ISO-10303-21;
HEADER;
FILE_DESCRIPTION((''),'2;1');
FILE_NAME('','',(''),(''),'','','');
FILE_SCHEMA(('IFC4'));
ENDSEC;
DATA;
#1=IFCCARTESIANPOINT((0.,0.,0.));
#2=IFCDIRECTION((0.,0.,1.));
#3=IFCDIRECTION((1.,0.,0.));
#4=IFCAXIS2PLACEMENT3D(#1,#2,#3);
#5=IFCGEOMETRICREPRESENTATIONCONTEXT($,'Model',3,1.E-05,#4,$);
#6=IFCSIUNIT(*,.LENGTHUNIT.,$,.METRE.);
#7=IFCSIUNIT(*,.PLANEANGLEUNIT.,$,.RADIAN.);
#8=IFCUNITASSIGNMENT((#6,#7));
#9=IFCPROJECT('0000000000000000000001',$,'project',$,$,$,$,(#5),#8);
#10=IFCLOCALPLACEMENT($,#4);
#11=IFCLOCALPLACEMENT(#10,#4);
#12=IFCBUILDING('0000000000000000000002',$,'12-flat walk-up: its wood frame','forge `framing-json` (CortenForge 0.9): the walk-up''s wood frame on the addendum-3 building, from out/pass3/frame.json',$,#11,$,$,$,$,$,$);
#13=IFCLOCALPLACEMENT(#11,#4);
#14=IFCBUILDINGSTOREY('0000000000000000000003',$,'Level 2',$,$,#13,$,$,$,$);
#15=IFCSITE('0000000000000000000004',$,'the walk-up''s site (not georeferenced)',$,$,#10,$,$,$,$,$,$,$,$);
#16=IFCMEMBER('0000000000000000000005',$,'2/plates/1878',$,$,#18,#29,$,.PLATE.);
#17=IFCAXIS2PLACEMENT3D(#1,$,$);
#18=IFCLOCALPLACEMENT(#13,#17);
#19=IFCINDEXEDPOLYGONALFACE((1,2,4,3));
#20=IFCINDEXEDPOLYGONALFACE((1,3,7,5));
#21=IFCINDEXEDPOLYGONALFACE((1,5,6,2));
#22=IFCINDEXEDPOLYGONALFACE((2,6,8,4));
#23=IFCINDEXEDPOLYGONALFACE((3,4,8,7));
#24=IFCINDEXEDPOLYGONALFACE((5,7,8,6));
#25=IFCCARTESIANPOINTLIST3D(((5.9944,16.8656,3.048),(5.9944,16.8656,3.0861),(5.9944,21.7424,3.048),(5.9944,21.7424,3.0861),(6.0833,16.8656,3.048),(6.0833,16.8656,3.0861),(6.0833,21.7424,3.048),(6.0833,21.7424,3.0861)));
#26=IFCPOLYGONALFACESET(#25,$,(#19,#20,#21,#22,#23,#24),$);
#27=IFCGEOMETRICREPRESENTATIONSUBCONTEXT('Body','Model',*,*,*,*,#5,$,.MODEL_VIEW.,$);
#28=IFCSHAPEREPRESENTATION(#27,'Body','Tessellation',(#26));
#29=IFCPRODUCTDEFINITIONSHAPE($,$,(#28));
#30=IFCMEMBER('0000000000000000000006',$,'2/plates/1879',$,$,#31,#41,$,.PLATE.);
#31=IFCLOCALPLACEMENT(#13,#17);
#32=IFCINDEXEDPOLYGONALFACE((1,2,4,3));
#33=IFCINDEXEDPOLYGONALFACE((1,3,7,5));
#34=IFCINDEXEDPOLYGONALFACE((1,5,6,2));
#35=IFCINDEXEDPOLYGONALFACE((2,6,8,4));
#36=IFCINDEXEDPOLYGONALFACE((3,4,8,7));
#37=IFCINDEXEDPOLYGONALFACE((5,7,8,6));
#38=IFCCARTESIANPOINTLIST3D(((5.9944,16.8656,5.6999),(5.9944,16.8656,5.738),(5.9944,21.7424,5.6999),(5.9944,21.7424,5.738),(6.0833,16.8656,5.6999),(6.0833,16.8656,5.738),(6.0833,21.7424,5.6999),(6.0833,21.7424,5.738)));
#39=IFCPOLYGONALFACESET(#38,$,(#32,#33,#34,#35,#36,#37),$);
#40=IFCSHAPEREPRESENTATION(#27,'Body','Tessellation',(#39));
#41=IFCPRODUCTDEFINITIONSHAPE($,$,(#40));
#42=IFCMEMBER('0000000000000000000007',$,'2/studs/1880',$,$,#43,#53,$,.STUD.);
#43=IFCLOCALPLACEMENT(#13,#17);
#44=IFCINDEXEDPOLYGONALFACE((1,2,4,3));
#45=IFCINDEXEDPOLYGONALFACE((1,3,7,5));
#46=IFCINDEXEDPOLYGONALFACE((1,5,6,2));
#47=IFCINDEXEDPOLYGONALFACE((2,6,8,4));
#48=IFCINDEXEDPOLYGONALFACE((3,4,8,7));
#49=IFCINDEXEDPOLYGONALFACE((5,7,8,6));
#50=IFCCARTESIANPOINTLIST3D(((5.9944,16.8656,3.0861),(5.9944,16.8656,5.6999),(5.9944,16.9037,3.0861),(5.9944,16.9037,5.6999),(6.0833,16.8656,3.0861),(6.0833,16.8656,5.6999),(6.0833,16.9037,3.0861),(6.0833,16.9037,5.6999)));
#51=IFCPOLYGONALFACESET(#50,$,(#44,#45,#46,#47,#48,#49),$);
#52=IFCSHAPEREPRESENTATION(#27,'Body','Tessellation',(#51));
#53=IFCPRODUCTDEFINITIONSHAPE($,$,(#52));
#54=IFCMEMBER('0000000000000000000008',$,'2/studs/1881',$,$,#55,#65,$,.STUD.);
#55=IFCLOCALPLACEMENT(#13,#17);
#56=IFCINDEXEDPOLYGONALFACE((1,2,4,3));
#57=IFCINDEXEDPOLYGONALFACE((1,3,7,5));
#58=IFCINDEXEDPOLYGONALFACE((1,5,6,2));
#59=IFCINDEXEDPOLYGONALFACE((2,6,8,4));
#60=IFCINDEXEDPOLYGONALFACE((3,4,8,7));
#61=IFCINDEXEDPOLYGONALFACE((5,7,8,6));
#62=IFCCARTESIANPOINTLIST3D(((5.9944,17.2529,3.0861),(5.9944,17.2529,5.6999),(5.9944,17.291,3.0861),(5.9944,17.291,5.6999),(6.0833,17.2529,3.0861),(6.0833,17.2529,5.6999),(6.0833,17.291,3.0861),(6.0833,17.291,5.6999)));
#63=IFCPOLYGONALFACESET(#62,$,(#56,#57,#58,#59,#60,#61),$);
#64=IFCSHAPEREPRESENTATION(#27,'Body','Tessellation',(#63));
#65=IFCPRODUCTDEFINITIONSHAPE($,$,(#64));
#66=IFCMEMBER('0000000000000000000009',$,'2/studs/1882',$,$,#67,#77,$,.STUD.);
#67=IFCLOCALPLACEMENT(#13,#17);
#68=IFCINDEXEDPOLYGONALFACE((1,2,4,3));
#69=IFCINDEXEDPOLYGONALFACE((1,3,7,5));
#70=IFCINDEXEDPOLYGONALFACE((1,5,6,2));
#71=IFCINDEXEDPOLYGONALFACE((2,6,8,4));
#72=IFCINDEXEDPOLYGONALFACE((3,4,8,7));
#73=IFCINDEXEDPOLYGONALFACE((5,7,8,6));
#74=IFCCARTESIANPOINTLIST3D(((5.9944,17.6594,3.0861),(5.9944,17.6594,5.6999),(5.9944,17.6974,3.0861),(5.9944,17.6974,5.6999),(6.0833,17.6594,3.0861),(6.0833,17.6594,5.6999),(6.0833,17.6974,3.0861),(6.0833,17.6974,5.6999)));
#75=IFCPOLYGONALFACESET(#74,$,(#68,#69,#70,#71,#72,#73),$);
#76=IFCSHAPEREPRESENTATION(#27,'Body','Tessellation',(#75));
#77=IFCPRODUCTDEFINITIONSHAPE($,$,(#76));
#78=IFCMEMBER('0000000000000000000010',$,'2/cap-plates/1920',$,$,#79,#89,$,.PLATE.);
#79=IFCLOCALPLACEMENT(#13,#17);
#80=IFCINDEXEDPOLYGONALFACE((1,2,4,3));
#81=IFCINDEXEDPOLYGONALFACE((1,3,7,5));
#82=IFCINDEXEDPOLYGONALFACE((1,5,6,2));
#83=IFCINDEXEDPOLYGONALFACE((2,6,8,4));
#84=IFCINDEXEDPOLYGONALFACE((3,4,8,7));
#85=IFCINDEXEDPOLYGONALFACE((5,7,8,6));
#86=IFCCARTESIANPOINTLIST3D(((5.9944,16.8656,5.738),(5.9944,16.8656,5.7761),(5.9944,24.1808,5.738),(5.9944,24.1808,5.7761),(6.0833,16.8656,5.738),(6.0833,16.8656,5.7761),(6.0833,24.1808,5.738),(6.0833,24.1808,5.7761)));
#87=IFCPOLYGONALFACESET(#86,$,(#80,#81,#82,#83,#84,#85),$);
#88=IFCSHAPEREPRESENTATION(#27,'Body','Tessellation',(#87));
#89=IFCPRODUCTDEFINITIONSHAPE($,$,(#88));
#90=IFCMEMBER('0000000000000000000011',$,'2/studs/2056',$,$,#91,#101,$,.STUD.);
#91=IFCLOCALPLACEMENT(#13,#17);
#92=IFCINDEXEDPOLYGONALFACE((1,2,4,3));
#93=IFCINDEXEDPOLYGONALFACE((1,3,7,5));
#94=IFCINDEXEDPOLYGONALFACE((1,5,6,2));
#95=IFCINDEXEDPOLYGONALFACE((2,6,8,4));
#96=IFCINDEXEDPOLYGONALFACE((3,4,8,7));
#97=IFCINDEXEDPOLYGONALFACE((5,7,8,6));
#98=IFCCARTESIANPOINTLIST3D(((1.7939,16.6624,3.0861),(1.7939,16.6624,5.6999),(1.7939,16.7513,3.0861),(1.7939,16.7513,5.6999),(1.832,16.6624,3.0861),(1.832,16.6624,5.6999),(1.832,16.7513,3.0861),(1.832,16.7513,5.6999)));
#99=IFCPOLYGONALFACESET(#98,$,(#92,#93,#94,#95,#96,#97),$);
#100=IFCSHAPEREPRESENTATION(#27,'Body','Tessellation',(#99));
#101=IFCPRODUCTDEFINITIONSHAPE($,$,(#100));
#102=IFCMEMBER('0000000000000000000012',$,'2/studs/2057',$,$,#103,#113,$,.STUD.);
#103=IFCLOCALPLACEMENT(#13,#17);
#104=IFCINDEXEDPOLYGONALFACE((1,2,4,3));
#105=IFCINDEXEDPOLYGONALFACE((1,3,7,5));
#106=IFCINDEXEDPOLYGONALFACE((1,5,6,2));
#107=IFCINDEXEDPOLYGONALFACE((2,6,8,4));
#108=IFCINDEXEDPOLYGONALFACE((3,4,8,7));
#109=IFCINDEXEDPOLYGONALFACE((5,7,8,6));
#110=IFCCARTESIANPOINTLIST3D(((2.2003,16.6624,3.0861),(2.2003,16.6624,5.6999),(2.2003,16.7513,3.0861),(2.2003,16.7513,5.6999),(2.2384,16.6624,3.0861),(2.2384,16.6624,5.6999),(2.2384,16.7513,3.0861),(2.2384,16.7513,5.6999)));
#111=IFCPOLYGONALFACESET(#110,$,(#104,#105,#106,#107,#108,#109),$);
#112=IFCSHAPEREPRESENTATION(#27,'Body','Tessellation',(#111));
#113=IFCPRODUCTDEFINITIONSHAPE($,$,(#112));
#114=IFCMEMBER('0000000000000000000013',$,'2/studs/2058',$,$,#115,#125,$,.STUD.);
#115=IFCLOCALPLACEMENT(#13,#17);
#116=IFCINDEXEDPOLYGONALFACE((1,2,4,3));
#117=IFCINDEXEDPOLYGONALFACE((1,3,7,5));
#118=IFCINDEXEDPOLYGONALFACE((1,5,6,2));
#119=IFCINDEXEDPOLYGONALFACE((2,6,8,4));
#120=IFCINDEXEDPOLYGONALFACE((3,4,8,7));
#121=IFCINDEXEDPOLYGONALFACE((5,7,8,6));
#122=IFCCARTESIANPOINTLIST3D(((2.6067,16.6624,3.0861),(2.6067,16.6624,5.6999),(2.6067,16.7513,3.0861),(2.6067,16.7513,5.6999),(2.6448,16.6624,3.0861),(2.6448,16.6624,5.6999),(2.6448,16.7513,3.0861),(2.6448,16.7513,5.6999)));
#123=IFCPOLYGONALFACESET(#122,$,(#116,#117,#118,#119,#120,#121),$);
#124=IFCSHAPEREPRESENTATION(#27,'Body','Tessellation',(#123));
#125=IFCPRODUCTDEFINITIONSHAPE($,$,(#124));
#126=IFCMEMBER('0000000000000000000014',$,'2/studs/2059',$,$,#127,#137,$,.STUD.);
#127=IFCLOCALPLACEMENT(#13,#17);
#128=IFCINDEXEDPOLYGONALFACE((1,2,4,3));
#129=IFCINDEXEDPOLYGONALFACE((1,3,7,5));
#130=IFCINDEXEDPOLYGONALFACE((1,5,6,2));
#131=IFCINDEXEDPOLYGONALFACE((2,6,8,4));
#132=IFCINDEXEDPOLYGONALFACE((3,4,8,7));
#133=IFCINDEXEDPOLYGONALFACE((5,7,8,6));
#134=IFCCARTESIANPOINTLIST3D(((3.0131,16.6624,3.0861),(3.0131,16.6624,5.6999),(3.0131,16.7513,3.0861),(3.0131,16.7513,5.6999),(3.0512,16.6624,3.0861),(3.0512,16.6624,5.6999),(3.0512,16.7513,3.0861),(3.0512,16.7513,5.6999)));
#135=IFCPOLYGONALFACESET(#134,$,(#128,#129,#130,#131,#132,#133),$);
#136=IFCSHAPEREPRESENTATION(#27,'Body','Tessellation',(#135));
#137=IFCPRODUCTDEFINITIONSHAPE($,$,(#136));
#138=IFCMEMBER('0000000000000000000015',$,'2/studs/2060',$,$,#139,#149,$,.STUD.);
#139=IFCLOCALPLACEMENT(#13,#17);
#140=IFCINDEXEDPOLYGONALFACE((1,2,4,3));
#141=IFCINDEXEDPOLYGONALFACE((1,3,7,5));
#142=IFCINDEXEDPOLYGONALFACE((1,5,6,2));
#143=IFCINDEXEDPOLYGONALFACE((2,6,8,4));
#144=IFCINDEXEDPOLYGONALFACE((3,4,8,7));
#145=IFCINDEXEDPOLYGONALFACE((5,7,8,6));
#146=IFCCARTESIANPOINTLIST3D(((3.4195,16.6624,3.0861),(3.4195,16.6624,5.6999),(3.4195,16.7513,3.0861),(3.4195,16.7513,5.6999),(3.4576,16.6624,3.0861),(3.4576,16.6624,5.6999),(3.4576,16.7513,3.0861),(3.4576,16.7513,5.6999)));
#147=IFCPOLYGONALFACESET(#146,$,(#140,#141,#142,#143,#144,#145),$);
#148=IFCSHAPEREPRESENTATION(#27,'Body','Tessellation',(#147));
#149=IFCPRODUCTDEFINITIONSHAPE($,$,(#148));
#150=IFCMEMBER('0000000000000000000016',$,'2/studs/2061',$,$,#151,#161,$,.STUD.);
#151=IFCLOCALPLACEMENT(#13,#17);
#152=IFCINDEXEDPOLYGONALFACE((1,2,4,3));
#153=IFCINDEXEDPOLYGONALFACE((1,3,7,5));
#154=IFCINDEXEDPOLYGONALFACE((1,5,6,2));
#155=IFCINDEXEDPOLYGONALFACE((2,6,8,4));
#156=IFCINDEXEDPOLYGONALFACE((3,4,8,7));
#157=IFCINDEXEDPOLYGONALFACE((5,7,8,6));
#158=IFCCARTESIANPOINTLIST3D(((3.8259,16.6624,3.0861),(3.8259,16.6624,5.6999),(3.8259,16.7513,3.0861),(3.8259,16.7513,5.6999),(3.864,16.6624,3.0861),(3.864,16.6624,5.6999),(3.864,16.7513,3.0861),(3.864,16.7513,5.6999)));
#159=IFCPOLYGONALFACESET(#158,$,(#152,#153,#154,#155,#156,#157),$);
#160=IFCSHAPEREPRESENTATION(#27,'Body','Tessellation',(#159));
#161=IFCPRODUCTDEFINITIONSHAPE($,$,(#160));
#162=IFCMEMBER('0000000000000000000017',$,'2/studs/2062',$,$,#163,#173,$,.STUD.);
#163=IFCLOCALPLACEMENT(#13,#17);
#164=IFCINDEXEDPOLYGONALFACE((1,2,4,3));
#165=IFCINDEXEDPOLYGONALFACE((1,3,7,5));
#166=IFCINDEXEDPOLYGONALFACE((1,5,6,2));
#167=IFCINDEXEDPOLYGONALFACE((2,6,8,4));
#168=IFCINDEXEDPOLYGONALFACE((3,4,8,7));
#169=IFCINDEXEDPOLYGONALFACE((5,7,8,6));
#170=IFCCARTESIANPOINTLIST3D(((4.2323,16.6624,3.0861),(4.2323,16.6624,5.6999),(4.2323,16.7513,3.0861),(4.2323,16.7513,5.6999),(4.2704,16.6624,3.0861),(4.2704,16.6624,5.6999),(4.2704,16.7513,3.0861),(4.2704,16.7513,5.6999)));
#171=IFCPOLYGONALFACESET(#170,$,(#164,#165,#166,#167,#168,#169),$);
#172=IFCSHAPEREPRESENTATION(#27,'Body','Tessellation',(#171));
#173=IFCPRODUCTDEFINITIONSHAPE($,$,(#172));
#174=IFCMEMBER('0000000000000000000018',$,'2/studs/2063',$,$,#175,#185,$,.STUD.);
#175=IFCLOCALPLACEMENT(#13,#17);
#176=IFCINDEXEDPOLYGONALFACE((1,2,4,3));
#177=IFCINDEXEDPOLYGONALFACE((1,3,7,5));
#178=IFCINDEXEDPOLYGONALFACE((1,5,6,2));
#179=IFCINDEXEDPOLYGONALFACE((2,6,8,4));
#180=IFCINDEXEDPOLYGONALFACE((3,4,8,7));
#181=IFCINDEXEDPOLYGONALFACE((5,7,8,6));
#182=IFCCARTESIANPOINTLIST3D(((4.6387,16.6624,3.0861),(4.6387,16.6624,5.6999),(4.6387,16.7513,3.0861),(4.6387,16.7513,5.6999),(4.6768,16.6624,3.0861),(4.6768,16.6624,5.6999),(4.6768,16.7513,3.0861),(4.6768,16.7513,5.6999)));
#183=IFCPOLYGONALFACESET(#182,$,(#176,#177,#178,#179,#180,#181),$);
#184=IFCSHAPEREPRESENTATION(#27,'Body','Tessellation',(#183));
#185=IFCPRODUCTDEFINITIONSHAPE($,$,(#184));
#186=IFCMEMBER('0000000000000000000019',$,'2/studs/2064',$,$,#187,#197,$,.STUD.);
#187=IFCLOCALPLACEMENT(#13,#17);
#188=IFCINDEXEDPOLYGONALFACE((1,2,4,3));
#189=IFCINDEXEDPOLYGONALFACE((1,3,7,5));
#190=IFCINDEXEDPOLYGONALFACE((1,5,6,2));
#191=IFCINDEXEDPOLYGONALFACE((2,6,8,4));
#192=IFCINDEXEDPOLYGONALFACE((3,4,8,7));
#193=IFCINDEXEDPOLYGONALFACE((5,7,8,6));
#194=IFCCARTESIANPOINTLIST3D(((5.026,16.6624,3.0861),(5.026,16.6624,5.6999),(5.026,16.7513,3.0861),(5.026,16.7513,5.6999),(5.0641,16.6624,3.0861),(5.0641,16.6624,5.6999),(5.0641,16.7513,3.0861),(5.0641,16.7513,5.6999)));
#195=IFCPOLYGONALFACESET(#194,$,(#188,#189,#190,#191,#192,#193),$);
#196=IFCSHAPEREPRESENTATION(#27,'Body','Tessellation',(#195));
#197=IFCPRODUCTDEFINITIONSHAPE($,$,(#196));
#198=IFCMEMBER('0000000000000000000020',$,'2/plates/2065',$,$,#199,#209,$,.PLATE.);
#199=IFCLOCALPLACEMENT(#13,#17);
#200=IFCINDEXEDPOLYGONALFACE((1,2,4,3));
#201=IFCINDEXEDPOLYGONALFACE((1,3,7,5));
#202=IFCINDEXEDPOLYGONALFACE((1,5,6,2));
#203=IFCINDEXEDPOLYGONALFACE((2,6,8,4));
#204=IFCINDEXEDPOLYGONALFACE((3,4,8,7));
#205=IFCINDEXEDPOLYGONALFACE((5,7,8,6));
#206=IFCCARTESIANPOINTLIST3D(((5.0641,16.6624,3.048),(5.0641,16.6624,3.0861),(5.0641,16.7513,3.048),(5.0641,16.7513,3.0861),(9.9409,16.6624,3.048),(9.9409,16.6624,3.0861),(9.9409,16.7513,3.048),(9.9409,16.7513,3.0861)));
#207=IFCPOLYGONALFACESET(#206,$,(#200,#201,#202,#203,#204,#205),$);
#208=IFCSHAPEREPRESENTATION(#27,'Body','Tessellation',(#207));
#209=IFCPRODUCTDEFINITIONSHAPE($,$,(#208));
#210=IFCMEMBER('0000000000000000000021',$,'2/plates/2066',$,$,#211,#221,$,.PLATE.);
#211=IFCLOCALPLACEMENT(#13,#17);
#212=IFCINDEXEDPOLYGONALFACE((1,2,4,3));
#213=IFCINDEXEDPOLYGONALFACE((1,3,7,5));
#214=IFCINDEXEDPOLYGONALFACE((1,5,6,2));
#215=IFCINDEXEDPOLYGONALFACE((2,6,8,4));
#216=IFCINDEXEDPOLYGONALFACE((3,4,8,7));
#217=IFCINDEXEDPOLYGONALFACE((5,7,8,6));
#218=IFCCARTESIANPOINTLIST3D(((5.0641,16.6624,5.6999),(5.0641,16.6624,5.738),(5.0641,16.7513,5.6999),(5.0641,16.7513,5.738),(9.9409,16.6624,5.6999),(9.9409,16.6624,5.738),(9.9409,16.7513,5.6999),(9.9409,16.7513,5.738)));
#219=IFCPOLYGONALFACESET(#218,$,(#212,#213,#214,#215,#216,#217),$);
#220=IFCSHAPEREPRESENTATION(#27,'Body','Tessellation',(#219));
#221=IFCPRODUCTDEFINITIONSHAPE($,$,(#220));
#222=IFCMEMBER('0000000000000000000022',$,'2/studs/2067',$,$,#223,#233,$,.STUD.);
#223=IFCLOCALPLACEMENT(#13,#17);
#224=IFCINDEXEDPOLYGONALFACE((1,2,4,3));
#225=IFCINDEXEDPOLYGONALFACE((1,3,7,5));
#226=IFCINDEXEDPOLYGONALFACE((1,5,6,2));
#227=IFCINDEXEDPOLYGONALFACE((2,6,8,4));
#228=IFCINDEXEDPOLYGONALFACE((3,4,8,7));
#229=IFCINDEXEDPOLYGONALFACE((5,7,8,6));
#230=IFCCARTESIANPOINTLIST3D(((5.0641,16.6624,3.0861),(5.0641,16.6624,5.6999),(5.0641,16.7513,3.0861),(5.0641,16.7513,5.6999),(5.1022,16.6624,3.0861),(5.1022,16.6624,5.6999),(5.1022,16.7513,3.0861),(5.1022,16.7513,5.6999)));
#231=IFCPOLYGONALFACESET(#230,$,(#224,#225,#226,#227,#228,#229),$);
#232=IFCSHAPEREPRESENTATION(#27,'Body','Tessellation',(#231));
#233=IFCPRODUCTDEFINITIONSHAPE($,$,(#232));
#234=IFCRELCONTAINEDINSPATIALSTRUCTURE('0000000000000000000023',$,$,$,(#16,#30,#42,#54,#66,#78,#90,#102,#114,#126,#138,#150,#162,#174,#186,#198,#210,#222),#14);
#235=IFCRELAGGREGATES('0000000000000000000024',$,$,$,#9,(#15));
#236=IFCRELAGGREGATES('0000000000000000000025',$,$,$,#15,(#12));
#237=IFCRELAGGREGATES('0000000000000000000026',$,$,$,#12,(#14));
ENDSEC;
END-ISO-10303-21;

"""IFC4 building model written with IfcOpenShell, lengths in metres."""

from ifc_helpers import new_model, si_unit, frame, frame_2d, origin, origin_with_axes, place, context, subcontext, project, spatial, rectangle, extrude, element, save


model = new_model("IFC4")

# Units and contexts
model_context = context("Model", 3, precision=1e-05, world=origin_with_axes())
body_context = subcontext(model_context, "Body", "Model", "MODEL_VIEW")
ifc_project = project(units=[si_unit("LENGTHUNIT", "METRE"), si_unit("PLANEANGLEUNIT", "RADIAN")], contexts=[model_context])

# Site, building, storey
site_placement = place(None, origin_with_axes())
site = spatial("IfcSite", under=ifc_project, at=site_placement, Name="the walk-up's site (not georeferenced)")
building_placement = place(site_placement, origin_with_axes())
building = spatial("IfcBuilding", under=site, at=building_placement, Name="12-flat walk-up: its wood frame", Description="forge `framing-json` (CortenForge 0.9): the walk-up's wood frame on the addendum-3 building, from out/pass3/frame.json")
storey_placement = place(building_placement, origin_with_axes())
storey = spatial("IfcBuildingStorey", under=building, at=storey_placement, Name="Level 2")

# Members
for number, where, z_axis, x_axis, name in (
    (1, (5.9944, 16.8656, 3.048), (0.0, 0.0, 1.0), (1.0, 0.0, 0.0), "2/plates/1878"),
    (2, (5.9944, 16.8656, 5.6999), (0.0, 0.0, 1.0), (1.0, 0.0, 0.0), "2/plates/1879"),
):
    element("IfcMember", number, at=place(storey_placement, frame(where, z_axis=z_axis, x_axis=x_axis)), inside=storey, Name=name, PredefinedType="PLATE", context=body_context, shape_type="SweptSolid", body=[
        extrude(rectangle(XDim=0.0889, YDim=4.8768, at=frame_2d((0.0445, 2.4384))), origin(), (0.0, 0.0, 1.0), 0.0381),
    ])
for number, where, z_axis, x_axis, name in (
    (3, (5.9944, 16.8656, 3.0861), (0.0, 0.0, 1.0), (1.0, 0.0, 0.0), "2/studs/1880"),
    (4, (5.9944, 17.2529, 3.0861), (0.0, 0.0, 1.0), (1.0, 0.0, 0.0), "2/studs/1881"),
    (5, (5.9944, 17.6593, 3.0861), (0.0, 0.0, 1.0), (1.0, 0.0, 0.0), "2/studs/1882"),
):
    element("IfcMember", number, at=place(storey_placement, frame(where, z_axis=z_axis, x_axis=x_axis)), inside=storey, Name=name, PredefinedType="STUD", context=body_context, shape_type="SweptSolid", body=[
        extrude(rectangle(XDim=0.0889, YDim=0.0381, at=frame_2d((0.0445, 0.0191))), origin(), (0.0, 0.0, 1.0), 2.6138),
    ])
member_1_placement = place(storey_placement, frame((5.9944, 16.8656, 5.738), z_axis=(0.0, 0.0, 1.0), x_axis=(1.0, 0.0, 0.0)))
element("IfcMember", 6, at=member_1_placement, inside=storey, Name="2/cap-plates/1920", PredefinedType="PLATE", context=body_context, shape_type="SweptSolid", body=[
    extrude(rectangle(XDim=0.0889, YDim=7.3152, at=frame_2d((0.0445, 3.6576))), origin(), (0.0, 0.0, 1.0), 0.0381),
])
member_2_placement = place(storey_placement, frame((1.7939, 16.6624, 3.0861), z_axis=(0.0, 0.0, 1.0), x_axis=(1.0, 0.0, 0.0)))
element("IfcMember", 7, at=member_2_placement, inside=storey, Name="2/studs/2056", PredefinedType="STUD", context=body_context, shape_type="SweptSolid", body=[
    extrude(rectangle(XDim=0.0381, YDim=0.0889, at=frame_2d((0.019, 0.0444))), origin(), (0.0, 0.0, 1.0), 2.6138),
])
for number, where, z_axis, x_axis, name in (
    (8, (2.2003, 16.6624, 3.0861), (0.0, 0.0, 1.0), (1.0, 0.0, 0.0), "2/studs/2057"),
    (9, (2.6067, 16.6624, 3.0861), (0.0, 0.0, 1.0), (1.0, 0.0, 0.0), "2/studs/2058"),
    (10, (3.0131, 16.6624, 3.0861), (0.0, 0.0, 1.0), (1.0, 0.0, 0.0), "2/studs/2059"),
    (11, (3.4195, 16.6624, 3.0861), (0.0, 0.0, 1.0), (1.0, 0.0, 0.0), "2/studs/2060"),
    (12, (3.8259, 16.6624, 3.0861), (0.0, 0.0, 1.0), (1.0, 0.0, 0.0), "2/studs/2061"),
    (13, (4.2323, 16.6624, 3.0861), (0.0, 0.0, 1.0), (1.0, 0.0, 0.0), "2/studs/2062"),
    (14, (4.6387, 16.6624, 3.0861), (0.0, 0.0, 1.0), (1.0, 0.0, 0.0), "2/studs/2063"),
    (15, (5.026, 16.6624, 3.0861), (0.0, 0.0, 1.0), (1.0, 0.0, 0.0), "2/studs/2064"),
):
    element("IfcMember", number, at=place(storey_placement, frame(where, z_axis=z_axis, x_axis=x_axis)), inside=storey, Name=name, PredefinedType="STUD", context=body_context, shape_type="SweptSolid", body=[
        extrude(rectangle(XDim=0.0381, YDim=0.0889, at=frame_2d((0.0191, 0.0444))), origin(), (0.0, 0.0, 1.0), 2.6138),
    ])
for number, where, z_axis, x_axis, name in (
    (16, (5.0641, 16.6624, 3.048), (0.0, 0.0, 1.0), (1.0, 0.0, 0.0), "2/plates/2065"),
    (17, (5.0641, 16.6624, 5.6999), (0.0, 0.0, 1.0), (1.0, 0.0, 0.0), "2/plates/2066"),
):
    element("IfcMember", number, at=place(storey_placement, frame(where, z_axis=z_axis, x_axis=x_axis)), inside=storey, Name=name, PredefinedType="PLATE", context=body_context, shape_type="SweptSolid", body=[
        extrude(rectangle(XDim=4.8768, YDim=0.0889, at=frame_2d((2.4384, 0.0444))), origin(), (0.0, 0.0, 1.0), 0.0381),
    ])
for number, where, z_axis, x_axis, name in (
    (18, (5.0641, 16.6624, 3.0861), (0.0, 0.0, 1.0), (1.0, 0.0, 0.0), "2/studs/2067"),
):
    element("IfcMember", number, at=place(storey_placement, frame(where, z_axis=z_axis, x_axis=x_axis)), inside=storey, Name=name, PredefinedType="STUD", context=body_context, shape_type="SweptSolid", body=[
        extrude(rectangle(XDim=0.0381, YDim=0.0889, at=frame_2d((0.0191, 0.0444))), origin(), (0.0, 0.0, 1.0), 2.6138),
    ])

save(model, "model.ifc")
